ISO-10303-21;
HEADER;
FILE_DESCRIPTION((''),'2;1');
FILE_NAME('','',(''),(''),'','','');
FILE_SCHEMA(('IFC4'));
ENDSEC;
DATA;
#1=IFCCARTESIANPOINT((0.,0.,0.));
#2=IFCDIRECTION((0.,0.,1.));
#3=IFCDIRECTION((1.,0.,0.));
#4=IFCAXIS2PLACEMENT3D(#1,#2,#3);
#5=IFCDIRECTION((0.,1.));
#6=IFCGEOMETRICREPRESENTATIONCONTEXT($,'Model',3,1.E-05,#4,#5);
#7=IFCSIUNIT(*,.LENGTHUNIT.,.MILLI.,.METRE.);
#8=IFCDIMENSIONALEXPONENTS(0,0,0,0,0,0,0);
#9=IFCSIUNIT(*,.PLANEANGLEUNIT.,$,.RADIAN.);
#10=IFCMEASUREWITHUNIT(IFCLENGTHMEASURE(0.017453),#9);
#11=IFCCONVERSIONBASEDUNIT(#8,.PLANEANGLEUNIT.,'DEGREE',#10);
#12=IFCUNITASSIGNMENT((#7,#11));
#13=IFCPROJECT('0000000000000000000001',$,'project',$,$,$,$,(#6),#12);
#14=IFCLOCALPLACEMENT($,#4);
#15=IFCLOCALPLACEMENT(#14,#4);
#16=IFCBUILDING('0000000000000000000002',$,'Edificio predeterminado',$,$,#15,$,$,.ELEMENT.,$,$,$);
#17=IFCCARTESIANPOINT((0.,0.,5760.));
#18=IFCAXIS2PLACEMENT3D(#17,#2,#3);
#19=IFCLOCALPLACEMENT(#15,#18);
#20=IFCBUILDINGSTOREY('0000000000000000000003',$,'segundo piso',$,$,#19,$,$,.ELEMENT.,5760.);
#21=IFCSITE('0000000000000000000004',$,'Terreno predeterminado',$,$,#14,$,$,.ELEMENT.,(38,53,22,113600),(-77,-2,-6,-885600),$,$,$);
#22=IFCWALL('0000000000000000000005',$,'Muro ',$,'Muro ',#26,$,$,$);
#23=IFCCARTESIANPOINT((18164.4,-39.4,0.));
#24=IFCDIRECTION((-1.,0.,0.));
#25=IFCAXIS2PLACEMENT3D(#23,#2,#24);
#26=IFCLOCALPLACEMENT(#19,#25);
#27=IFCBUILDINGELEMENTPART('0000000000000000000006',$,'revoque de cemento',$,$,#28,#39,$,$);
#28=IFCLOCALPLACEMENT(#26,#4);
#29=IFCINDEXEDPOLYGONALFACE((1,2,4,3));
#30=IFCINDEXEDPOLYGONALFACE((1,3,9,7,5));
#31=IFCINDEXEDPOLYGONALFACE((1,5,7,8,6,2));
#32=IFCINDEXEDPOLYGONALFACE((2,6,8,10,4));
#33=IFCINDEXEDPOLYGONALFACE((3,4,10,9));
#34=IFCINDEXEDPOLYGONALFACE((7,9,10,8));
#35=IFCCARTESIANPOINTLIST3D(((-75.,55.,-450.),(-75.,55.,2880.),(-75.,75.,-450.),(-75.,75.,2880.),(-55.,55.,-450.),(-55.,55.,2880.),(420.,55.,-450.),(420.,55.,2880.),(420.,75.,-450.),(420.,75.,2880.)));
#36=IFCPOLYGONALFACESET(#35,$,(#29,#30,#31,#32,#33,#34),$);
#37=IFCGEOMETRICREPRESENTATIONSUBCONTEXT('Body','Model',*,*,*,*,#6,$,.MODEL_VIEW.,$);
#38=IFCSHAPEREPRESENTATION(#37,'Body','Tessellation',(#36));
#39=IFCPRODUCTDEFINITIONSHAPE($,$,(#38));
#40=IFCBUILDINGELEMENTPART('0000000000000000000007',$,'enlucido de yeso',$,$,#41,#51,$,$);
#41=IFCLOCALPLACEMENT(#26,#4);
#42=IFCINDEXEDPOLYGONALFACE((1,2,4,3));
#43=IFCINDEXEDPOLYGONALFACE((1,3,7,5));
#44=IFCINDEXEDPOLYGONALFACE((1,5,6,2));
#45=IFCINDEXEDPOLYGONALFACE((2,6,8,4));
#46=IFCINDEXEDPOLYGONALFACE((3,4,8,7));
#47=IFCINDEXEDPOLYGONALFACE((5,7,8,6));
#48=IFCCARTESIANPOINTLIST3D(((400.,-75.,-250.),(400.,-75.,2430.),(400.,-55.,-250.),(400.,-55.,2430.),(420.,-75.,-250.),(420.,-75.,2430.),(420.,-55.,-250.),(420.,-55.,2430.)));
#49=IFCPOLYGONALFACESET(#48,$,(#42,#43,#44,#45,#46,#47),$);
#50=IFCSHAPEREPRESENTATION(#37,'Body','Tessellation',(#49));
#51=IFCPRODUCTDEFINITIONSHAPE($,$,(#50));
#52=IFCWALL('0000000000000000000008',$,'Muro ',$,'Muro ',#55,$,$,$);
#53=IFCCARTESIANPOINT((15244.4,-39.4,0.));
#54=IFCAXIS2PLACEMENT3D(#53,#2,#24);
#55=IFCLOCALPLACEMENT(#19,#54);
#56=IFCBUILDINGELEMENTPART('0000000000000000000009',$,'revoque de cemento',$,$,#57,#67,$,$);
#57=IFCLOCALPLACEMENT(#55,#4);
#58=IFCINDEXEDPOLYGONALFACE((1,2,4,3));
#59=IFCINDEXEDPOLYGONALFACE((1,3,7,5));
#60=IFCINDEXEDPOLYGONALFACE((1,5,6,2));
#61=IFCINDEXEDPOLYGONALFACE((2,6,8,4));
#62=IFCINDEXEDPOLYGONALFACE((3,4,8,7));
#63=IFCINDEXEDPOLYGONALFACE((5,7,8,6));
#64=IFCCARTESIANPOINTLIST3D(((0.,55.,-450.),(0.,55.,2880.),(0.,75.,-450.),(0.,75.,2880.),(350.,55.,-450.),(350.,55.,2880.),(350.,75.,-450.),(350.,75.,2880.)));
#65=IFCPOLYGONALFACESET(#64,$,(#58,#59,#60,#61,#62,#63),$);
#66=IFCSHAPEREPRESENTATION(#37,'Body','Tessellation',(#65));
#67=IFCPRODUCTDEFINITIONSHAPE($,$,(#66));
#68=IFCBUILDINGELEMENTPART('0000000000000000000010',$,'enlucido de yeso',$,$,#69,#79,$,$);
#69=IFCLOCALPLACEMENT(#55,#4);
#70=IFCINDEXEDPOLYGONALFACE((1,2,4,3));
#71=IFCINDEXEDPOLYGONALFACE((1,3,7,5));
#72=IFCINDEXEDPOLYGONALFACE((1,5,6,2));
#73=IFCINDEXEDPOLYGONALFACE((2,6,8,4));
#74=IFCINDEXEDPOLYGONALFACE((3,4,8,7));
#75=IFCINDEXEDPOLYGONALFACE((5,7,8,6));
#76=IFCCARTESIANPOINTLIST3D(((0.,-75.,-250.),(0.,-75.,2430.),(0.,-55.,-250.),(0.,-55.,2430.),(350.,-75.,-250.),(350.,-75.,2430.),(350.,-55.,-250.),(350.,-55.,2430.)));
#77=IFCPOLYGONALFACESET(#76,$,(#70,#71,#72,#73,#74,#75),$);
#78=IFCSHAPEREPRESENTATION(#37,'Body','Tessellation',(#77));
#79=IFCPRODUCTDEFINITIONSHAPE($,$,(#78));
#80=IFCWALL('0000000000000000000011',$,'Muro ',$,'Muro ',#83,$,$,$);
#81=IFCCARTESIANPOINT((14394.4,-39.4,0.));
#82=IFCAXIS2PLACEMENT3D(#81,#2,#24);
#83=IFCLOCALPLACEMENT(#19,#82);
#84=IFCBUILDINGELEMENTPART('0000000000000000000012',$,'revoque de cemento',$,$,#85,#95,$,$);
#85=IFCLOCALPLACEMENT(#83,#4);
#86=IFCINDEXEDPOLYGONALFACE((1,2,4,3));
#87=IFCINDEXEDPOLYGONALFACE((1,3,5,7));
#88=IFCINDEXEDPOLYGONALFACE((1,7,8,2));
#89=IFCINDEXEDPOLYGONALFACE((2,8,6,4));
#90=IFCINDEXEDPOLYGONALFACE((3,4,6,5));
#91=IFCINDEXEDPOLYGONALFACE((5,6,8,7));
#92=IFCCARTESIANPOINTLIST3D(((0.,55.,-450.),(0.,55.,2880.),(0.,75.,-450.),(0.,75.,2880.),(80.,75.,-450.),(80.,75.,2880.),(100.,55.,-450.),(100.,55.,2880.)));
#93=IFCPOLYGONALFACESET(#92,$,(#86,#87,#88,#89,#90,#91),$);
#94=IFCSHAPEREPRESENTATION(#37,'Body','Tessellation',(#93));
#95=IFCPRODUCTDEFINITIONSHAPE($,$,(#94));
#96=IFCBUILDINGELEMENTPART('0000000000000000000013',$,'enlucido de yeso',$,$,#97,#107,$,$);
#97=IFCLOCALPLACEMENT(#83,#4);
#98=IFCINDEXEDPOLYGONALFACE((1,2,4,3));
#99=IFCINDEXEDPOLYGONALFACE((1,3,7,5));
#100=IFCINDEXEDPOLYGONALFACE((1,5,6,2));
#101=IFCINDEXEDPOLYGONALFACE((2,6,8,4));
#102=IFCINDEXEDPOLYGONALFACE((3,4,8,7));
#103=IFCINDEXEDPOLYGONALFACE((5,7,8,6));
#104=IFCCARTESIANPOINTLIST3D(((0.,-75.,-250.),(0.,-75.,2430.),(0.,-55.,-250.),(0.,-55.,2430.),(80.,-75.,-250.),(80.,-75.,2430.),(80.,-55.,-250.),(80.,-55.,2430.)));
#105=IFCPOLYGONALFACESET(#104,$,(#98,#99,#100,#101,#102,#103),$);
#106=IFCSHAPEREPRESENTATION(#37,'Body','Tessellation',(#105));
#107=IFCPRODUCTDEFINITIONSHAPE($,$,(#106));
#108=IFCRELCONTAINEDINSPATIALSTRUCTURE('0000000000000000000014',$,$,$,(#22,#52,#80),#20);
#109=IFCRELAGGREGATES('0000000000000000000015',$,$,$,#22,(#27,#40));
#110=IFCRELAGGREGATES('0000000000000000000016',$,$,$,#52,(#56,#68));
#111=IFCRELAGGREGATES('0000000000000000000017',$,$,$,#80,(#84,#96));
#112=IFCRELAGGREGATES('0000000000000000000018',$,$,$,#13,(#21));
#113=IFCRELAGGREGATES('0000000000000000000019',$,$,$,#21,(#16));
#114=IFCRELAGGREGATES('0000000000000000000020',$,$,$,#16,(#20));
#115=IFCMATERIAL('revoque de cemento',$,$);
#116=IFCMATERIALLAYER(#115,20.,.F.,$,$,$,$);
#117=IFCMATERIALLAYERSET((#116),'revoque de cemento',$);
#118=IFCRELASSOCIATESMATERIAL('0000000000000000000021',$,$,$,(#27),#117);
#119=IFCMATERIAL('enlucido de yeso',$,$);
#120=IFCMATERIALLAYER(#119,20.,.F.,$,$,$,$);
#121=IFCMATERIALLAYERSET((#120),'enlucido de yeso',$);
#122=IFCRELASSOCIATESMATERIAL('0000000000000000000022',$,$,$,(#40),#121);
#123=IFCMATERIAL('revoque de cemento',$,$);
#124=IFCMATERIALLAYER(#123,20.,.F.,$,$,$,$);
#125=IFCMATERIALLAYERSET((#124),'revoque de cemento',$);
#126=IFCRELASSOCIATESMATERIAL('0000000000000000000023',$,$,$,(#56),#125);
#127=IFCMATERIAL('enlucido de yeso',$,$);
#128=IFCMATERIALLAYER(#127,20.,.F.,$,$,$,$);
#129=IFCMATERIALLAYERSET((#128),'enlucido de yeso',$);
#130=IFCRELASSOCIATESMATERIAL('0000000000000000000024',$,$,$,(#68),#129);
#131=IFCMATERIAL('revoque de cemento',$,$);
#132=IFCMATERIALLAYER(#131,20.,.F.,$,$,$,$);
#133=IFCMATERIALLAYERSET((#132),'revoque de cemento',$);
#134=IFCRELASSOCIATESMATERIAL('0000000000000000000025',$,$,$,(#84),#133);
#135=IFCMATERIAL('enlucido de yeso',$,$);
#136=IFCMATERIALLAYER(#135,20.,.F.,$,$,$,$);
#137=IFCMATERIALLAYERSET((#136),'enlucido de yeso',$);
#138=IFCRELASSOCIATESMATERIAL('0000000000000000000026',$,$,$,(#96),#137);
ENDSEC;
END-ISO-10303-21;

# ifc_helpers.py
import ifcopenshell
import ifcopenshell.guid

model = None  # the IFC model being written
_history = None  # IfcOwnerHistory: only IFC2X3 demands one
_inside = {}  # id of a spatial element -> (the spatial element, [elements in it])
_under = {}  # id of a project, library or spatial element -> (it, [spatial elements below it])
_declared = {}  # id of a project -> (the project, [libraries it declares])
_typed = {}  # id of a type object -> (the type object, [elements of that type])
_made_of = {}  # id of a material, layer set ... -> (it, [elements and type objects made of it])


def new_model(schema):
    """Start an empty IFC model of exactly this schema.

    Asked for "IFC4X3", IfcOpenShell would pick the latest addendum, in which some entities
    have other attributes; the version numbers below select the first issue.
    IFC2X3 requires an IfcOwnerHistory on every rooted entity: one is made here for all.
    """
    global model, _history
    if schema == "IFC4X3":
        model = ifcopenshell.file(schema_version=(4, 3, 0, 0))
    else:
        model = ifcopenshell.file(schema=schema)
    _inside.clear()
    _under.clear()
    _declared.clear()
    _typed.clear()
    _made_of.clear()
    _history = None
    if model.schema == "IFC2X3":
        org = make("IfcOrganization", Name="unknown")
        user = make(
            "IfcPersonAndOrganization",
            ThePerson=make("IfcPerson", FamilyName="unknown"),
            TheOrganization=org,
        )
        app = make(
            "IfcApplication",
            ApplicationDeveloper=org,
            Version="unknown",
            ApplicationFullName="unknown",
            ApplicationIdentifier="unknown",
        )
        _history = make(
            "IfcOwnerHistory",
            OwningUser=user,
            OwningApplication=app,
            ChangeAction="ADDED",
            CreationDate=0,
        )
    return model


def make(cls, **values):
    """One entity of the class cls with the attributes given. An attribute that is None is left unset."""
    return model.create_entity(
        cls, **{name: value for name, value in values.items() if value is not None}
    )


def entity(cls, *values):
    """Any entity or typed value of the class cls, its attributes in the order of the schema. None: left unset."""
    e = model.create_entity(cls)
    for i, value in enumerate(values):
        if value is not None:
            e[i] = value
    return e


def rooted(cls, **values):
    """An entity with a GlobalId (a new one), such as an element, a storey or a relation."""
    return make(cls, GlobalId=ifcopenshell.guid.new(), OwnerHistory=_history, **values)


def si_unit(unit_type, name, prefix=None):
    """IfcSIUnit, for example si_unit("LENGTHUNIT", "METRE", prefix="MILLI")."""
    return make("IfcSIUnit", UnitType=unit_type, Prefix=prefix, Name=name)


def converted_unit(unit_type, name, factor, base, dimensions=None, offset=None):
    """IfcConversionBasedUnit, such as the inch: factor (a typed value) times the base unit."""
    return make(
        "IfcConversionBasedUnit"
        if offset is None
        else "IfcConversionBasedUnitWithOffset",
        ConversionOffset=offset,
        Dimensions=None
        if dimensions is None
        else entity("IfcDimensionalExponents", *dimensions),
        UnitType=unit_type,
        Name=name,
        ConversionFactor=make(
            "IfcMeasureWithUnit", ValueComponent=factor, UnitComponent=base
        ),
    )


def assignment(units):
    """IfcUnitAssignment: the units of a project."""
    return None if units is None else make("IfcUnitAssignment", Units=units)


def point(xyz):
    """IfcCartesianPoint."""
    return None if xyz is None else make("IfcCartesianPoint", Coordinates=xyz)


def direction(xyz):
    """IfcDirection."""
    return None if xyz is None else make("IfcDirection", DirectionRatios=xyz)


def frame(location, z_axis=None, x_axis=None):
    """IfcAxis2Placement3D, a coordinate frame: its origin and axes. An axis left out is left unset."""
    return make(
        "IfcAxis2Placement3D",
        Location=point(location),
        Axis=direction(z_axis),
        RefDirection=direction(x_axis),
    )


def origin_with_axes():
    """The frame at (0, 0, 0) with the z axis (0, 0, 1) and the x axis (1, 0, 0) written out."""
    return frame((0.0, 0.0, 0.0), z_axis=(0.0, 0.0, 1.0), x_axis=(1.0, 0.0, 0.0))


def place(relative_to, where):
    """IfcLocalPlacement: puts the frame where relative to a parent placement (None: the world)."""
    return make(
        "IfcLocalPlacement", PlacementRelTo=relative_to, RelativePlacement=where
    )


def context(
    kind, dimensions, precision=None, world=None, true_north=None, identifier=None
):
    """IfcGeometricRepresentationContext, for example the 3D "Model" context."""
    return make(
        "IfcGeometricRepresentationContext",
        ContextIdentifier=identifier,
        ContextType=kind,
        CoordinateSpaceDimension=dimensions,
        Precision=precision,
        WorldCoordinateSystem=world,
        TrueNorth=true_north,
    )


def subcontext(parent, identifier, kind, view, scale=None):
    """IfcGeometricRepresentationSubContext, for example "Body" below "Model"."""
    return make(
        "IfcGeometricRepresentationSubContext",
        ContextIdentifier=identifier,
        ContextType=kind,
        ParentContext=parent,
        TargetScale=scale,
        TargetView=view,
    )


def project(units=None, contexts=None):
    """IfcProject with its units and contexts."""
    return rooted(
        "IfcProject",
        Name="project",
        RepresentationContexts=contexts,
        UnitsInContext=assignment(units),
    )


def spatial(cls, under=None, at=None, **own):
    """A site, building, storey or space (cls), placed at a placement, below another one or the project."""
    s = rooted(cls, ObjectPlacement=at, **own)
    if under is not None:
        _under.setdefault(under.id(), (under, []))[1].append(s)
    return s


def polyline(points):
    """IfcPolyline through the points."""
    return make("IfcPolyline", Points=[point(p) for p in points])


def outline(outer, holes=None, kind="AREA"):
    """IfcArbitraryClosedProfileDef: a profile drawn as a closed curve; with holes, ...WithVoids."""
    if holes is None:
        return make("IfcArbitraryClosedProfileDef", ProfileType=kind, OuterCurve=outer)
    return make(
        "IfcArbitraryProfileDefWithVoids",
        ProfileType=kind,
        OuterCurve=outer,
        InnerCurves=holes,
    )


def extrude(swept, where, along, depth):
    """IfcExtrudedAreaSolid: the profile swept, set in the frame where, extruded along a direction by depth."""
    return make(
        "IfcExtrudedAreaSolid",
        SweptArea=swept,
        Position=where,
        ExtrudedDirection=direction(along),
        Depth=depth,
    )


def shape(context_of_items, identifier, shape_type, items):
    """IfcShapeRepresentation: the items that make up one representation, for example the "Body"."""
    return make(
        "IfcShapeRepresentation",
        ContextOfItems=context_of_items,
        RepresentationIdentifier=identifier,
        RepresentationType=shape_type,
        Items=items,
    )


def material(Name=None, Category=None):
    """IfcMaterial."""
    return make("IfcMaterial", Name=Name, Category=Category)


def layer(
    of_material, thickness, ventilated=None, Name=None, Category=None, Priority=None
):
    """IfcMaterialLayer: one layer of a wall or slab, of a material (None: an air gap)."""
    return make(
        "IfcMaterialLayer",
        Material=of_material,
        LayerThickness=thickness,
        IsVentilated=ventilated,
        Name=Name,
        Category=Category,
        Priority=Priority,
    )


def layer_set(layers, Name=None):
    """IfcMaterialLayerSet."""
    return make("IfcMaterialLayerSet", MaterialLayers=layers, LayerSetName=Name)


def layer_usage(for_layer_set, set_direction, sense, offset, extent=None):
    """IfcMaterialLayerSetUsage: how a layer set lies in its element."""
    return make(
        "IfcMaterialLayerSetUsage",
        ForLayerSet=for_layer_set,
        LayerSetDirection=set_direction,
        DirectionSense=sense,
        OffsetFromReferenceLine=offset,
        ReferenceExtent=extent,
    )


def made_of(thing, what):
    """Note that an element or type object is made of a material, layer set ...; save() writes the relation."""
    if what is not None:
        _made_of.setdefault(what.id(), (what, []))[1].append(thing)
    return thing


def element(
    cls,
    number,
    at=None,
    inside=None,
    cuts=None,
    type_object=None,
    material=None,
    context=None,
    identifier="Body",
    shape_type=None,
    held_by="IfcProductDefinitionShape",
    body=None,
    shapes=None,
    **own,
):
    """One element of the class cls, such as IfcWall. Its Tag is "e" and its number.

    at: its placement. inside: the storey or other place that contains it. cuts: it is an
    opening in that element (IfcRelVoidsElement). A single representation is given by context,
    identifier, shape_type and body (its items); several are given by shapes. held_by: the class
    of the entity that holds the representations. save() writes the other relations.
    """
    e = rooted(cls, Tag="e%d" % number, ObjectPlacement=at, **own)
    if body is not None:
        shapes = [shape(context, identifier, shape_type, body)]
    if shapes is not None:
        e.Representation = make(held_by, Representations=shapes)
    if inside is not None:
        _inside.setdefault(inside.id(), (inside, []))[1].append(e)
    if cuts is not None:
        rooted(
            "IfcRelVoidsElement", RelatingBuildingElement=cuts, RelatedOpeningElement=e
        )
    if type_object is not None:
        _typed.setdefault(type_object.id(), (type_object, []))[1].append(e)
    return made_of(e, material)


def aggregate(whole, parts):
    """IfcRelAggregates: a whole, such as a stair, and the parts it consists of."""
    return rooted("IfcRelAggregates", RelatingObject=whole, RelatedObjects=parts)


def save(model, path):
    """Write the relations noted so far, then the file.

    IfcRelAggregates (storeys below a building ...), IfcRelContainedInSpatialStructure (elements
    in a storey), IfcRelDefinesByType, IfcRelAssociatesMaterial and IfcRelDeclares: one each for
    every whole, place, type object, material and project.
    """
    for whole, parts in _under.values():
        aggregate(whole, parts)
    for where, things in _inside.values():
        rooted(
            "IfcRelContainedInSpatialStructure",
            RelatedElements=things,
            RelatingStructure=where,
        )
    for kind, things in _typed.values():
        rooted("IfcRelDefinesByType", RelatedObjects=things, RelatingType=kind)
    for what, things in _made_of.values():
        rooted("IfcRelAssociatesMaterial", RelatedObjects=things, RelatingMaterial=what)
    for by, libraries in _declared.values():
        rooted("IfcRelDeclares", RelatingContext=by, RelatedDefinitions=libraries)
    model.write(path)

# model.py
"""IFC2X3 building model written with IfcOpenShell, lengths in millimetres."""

from ifc_helpers import new_model, entity, si_unit, converted_unit, direction, frame, origin_with_axes, place, context, subcontext, project, spatial, polyline, outline, extrude, material, layer, layer_set, layer_usage, element, aggregate, save


model = new_model("IFC2X3")

# Units and contexts
model_context = context("Model", 3, precision=1e-05, world=origin_with_axes(), true_north=direction((0.0, 1.0)))
body_context = subcontext(model_context, "Body", "Model", "MODEL_VIEW")
ifc_project = project(units=[si_unit("LENGTHUNIT", "METRE", prefix="MILLI"), converted_unit("PLANEANGLEUNIT", "DEGREE", entity("IfcLengthMeasure", 0.017453), si_unit("PLANEANGLEUNIT", "RADIAN"), dimensions=[0, 0, 0, 0, 0, 0, 0])], contexts=[model_context])

# Site, building, storey
site_placement = place(None, origin_with_axes())
site = spatial("IfcSite", under=ifc_project, at=site_placement, Name="Terreno predeterminado", CompositionType="ELEMENT", RefLatitude=(38, 53, 22, 113600), RefLongitude=(-77, -2, -6, -885600))
building_placement = place(site_placement, origin_with_axes())
building = spatial("IfcBuilding", under=site, at=building_placement, Name="Edificio predeterminado", CompositionType="ELEMENT")
storey_placement = place(building_placement, frame((0.0, 0.0, 5760.0), z_axis=(0.0, 0.0, 1.0), x_axis=(1.0, 0.0, 0.0)))
storey = spatial("IfcBuildingStorey", under=building, at=storey_placement, Name="segundo piso", CompositionType="ELEMENT", Elevation=5760.0)

# Walls, building element parts
wall_1_placement = place(storey_placement, frame((18164.4, -39.4, 0.0), z_axis=(0.0, 0.0, 1.0), x_axis=(-1.0, 0.0, 0.0)))
wall_1 = element("IfcWall", 1, at=wall_1_placement, inside=storey, Name="Muro ", ObjectType="Muro ")
ifc_material_1 = material(Name="revoque de cemento")
ifc_layer_1 = layer(ifc_material_1, 20.0, ventilated=False)
ifc_layer_set_1 = layer_set([ifc_layer_1], Name="revoque de cemento")
ifc_layer_usage_1 = layer_usage(ifc_layer_set_1, "AXIS2", "NEGATIVE", -75.0)
building_element_part_1_placement = place(wall_1_placement, origin_with_axes())
building_element_part_1 = element("IfcBuildingElementPart", 2, at=building_element_part_1_placement, material=ifc_layer_usage_1, Name="revoque de cemento", context=body_context, shape_type="SweptSolid", body=[
    extrude(outline(polyline([(420.0, 75.0), (420.0, 55.0), (-55.0, 55.0), (-75.0, 55.0), (-75.0, 75.0), (420.0, 75.0)])), frame((0.0, 0.0, -450.0), z_axis=(0.0, 0.0, 1.0), x_axis=(1.0, 0.0, 0.0)), (0.0, 0.0, 1.0), 3330.0),
])
ifc_material_2 = material(Name="enlucido de yeso")
ifc_layer_2 = layer(ifc_material_2, 20.0, ventilated=False)
ifc_layer_set_2 = layer_set([ifc_layer_2], Name="enlucido de yeso")
ifc_layer_usage_2 = layer_usage(ifc_layer_set_2, "AXIS2", "NEGATIVE", 55.0)
building_element_part_2_placement = place(wall_1_placement, origin_with_axes())
building_element_part_2 = element("IfcBuildingElementPart", 3, at=building_element_part_2_placement, material=ifc_layer_usage_2, Name="enlucido de yeso", context=body_context, shape_type="SweptSolid", body=[
    extrude(outline(polyline([(420.0, -55.0), (420.0, -75.0), (400.0, -75.0), (400.0, -55.0), (420.0, -55.0)])), frame((0.0, 0.0, -250.0), z_axis=(0.0, 0.0, 1.0), x_axis=(1.0, 0.0, 0.0)), (0.0, 0.0, 1.0), 2680.0),
])
aggregate(wall_1, [building_element_part_1, building_element_part_2])
wall_2_placement = place(storey_placement, frame((15244.4, -39.4, 0.0), z_axis=(0.0, 0.0, 1.0), x_axis=(-1.0, 0.0, 0.0)))
wall_2 = element("IfcWall", 4, at=wall_2_placement, inside=storey, Name="Muro ", ObjectType="Muro ")
ifc_material_3 = material(Name="revoque de cemento")
ifc_layer_3 = layer(ifc_material_3, 20.0, ventilated=False)
ifc_layer_set_3 = layer_set([ifc_layer_3], Name="revoque de cemento")
ifc_layer_usage_3 = layer_usage(ifc_layer_set_3, "AXIS2", "NEGATIVE", -75.0)
building_element_part_3_placement = place(wall_2_placement, origin_with_axes())
building_element_part_3 = element("IfcBuildingElementPart", 5, at=building_element_part_3_placement, material=ifc_layer_usage_3, Name="revoque de cemento", context=body_context, shape_type="SweptSolid", body=[
    extrude(outline(polyline([(350.0, 75.0), (350.0, 55.0), (0.0, 55.0), (0.0, 75.0), (350.0, 75.0)])), frame((0.0, 0.0, -450.0), z_axis=(0.0, 0.0, 1.0), x_axis=(1.0, 0.0, 0.0)), (0.0, 0.0, 1.0), 3330.0),
])
ifc_material_4 = material(Name="enlucido de yeso")
ifc_layer_4 = layer(ifc_material_4, 20.0, ventilated=False)
ifc_layer_set_4 = layer_set([ifc_layer_4], Name="enlucido de yeso")
ifc_layer_usage_4 = layer_usage(ifc_layer_set_4, "AXIS2", "NEGATIVE", 55.0)
building_element_part_4_placement = place(wall_2_placement, origin_with_axes())
building_element_part_4 = element("IfcBuildingElementPart", 6, at=building_element_part_4_placement, material=ifc_layer_usage_4, Name="enlucido de yeso", context=body_context, shape_type="SweptSolid", body=[
    extrude(outline(polyline([(350.0, -55.0), (350.0, -75.0), (0.0, -75.0), (0.0, -55.0), (350.0, -55.0)])), frame((0.0, 0.0, -250.0), z_axis=(0.0, 0.0, 1.0), x_axis=(1.0, 0.0, 0.0)), (0.0, 0.0, 1.0), 2680.0),
])
aggregate(wall_2, [building_element_part_3, building_element_part_4])
wall_3_placement = place(storey_placement, frame((14394.4, -39.4, 0.0), z_axis=(0.0, 0.0, 1.0), x_axis=(-1.0, 0.0, 0.0)))
wall_3 = element("IfcWall", 7, at=wall_3_placement, inside=storey, Name="Muro ", ObjectType="Muro ")
ifc_material_5 = material(Name="revoque de cemento")
ifc_layer_5 = layer(ifc_material_5, 20.0, ventilated=False)
ifc_layer_set_5 = layer_set([ifc_layer_5], Name="revoque de cemento")
ifc_layer_usage_5 = layer_usage(ifc_layer_set_5, "AXIS2", "NEGATIVE", -75.0)
building_element_part_5_placement = place(wall_3_placement, origin_with_axes())
building_element_part_5 = element("IfcBuildingElementPart", 8, at=building_element_part_5_placement, material=ifc_layer_usage_5, Name="revoque de cemento", context=body_context, shape_type="SweptSolid", body=[
    extrude(outline(polyline([(80.0, 75.0), (100.0, 55.0), (0.0, 55.0), (0.0, 75.0), (80.0, 75.0)])), frame((0.0, 0.0, -450.0), z_axis=(0.0, 0.0, 1.0), x_axis=(1.0, 0.0, 0.0)), (0.0, 0.0, 1.0), 3330.0),
])
ifc_material_6 = material(Name="enlucido de yeso")
ifc_layer_6 = layer(ifc_material_6, 20.0, ventilated=False)
ifc_layer_set_6 = layer_set([ifc_layer_6], Name="enlucido de yeso")
ifc_layer_usage_6 = layer_usage(ifc_layer_set_6, "AXIS2", "NEGATIVE", 55.0)
building_element_part_6_placement = place(wall_3_placement, origin_with_axes())
building_element_part_6 = element("IfcBuildingElementPart", 9, at=building_element_part_6_placement, material=ifc_layer_usage_6, Name="enlucido de yeso", context=body_context, shape_type="SweptSolid", body=[
    extrude(outline(polyline([(80.0, -55.0), (80.0, -75.0), (0.0, -75.0), (0.0, -55.0), (80.0, -55.0)])), frame((0.0, 0.0, -250.0), z_axis=(0.0, 0.0, 1.0), x_axis=(1.0, 0.0, 0.0)), (0.0, 0.0, 1.0), 2680.0),
])
aggregate(wall_3, [building_element_part_5, building_element_part_6])

save(model, "model.ifc")
